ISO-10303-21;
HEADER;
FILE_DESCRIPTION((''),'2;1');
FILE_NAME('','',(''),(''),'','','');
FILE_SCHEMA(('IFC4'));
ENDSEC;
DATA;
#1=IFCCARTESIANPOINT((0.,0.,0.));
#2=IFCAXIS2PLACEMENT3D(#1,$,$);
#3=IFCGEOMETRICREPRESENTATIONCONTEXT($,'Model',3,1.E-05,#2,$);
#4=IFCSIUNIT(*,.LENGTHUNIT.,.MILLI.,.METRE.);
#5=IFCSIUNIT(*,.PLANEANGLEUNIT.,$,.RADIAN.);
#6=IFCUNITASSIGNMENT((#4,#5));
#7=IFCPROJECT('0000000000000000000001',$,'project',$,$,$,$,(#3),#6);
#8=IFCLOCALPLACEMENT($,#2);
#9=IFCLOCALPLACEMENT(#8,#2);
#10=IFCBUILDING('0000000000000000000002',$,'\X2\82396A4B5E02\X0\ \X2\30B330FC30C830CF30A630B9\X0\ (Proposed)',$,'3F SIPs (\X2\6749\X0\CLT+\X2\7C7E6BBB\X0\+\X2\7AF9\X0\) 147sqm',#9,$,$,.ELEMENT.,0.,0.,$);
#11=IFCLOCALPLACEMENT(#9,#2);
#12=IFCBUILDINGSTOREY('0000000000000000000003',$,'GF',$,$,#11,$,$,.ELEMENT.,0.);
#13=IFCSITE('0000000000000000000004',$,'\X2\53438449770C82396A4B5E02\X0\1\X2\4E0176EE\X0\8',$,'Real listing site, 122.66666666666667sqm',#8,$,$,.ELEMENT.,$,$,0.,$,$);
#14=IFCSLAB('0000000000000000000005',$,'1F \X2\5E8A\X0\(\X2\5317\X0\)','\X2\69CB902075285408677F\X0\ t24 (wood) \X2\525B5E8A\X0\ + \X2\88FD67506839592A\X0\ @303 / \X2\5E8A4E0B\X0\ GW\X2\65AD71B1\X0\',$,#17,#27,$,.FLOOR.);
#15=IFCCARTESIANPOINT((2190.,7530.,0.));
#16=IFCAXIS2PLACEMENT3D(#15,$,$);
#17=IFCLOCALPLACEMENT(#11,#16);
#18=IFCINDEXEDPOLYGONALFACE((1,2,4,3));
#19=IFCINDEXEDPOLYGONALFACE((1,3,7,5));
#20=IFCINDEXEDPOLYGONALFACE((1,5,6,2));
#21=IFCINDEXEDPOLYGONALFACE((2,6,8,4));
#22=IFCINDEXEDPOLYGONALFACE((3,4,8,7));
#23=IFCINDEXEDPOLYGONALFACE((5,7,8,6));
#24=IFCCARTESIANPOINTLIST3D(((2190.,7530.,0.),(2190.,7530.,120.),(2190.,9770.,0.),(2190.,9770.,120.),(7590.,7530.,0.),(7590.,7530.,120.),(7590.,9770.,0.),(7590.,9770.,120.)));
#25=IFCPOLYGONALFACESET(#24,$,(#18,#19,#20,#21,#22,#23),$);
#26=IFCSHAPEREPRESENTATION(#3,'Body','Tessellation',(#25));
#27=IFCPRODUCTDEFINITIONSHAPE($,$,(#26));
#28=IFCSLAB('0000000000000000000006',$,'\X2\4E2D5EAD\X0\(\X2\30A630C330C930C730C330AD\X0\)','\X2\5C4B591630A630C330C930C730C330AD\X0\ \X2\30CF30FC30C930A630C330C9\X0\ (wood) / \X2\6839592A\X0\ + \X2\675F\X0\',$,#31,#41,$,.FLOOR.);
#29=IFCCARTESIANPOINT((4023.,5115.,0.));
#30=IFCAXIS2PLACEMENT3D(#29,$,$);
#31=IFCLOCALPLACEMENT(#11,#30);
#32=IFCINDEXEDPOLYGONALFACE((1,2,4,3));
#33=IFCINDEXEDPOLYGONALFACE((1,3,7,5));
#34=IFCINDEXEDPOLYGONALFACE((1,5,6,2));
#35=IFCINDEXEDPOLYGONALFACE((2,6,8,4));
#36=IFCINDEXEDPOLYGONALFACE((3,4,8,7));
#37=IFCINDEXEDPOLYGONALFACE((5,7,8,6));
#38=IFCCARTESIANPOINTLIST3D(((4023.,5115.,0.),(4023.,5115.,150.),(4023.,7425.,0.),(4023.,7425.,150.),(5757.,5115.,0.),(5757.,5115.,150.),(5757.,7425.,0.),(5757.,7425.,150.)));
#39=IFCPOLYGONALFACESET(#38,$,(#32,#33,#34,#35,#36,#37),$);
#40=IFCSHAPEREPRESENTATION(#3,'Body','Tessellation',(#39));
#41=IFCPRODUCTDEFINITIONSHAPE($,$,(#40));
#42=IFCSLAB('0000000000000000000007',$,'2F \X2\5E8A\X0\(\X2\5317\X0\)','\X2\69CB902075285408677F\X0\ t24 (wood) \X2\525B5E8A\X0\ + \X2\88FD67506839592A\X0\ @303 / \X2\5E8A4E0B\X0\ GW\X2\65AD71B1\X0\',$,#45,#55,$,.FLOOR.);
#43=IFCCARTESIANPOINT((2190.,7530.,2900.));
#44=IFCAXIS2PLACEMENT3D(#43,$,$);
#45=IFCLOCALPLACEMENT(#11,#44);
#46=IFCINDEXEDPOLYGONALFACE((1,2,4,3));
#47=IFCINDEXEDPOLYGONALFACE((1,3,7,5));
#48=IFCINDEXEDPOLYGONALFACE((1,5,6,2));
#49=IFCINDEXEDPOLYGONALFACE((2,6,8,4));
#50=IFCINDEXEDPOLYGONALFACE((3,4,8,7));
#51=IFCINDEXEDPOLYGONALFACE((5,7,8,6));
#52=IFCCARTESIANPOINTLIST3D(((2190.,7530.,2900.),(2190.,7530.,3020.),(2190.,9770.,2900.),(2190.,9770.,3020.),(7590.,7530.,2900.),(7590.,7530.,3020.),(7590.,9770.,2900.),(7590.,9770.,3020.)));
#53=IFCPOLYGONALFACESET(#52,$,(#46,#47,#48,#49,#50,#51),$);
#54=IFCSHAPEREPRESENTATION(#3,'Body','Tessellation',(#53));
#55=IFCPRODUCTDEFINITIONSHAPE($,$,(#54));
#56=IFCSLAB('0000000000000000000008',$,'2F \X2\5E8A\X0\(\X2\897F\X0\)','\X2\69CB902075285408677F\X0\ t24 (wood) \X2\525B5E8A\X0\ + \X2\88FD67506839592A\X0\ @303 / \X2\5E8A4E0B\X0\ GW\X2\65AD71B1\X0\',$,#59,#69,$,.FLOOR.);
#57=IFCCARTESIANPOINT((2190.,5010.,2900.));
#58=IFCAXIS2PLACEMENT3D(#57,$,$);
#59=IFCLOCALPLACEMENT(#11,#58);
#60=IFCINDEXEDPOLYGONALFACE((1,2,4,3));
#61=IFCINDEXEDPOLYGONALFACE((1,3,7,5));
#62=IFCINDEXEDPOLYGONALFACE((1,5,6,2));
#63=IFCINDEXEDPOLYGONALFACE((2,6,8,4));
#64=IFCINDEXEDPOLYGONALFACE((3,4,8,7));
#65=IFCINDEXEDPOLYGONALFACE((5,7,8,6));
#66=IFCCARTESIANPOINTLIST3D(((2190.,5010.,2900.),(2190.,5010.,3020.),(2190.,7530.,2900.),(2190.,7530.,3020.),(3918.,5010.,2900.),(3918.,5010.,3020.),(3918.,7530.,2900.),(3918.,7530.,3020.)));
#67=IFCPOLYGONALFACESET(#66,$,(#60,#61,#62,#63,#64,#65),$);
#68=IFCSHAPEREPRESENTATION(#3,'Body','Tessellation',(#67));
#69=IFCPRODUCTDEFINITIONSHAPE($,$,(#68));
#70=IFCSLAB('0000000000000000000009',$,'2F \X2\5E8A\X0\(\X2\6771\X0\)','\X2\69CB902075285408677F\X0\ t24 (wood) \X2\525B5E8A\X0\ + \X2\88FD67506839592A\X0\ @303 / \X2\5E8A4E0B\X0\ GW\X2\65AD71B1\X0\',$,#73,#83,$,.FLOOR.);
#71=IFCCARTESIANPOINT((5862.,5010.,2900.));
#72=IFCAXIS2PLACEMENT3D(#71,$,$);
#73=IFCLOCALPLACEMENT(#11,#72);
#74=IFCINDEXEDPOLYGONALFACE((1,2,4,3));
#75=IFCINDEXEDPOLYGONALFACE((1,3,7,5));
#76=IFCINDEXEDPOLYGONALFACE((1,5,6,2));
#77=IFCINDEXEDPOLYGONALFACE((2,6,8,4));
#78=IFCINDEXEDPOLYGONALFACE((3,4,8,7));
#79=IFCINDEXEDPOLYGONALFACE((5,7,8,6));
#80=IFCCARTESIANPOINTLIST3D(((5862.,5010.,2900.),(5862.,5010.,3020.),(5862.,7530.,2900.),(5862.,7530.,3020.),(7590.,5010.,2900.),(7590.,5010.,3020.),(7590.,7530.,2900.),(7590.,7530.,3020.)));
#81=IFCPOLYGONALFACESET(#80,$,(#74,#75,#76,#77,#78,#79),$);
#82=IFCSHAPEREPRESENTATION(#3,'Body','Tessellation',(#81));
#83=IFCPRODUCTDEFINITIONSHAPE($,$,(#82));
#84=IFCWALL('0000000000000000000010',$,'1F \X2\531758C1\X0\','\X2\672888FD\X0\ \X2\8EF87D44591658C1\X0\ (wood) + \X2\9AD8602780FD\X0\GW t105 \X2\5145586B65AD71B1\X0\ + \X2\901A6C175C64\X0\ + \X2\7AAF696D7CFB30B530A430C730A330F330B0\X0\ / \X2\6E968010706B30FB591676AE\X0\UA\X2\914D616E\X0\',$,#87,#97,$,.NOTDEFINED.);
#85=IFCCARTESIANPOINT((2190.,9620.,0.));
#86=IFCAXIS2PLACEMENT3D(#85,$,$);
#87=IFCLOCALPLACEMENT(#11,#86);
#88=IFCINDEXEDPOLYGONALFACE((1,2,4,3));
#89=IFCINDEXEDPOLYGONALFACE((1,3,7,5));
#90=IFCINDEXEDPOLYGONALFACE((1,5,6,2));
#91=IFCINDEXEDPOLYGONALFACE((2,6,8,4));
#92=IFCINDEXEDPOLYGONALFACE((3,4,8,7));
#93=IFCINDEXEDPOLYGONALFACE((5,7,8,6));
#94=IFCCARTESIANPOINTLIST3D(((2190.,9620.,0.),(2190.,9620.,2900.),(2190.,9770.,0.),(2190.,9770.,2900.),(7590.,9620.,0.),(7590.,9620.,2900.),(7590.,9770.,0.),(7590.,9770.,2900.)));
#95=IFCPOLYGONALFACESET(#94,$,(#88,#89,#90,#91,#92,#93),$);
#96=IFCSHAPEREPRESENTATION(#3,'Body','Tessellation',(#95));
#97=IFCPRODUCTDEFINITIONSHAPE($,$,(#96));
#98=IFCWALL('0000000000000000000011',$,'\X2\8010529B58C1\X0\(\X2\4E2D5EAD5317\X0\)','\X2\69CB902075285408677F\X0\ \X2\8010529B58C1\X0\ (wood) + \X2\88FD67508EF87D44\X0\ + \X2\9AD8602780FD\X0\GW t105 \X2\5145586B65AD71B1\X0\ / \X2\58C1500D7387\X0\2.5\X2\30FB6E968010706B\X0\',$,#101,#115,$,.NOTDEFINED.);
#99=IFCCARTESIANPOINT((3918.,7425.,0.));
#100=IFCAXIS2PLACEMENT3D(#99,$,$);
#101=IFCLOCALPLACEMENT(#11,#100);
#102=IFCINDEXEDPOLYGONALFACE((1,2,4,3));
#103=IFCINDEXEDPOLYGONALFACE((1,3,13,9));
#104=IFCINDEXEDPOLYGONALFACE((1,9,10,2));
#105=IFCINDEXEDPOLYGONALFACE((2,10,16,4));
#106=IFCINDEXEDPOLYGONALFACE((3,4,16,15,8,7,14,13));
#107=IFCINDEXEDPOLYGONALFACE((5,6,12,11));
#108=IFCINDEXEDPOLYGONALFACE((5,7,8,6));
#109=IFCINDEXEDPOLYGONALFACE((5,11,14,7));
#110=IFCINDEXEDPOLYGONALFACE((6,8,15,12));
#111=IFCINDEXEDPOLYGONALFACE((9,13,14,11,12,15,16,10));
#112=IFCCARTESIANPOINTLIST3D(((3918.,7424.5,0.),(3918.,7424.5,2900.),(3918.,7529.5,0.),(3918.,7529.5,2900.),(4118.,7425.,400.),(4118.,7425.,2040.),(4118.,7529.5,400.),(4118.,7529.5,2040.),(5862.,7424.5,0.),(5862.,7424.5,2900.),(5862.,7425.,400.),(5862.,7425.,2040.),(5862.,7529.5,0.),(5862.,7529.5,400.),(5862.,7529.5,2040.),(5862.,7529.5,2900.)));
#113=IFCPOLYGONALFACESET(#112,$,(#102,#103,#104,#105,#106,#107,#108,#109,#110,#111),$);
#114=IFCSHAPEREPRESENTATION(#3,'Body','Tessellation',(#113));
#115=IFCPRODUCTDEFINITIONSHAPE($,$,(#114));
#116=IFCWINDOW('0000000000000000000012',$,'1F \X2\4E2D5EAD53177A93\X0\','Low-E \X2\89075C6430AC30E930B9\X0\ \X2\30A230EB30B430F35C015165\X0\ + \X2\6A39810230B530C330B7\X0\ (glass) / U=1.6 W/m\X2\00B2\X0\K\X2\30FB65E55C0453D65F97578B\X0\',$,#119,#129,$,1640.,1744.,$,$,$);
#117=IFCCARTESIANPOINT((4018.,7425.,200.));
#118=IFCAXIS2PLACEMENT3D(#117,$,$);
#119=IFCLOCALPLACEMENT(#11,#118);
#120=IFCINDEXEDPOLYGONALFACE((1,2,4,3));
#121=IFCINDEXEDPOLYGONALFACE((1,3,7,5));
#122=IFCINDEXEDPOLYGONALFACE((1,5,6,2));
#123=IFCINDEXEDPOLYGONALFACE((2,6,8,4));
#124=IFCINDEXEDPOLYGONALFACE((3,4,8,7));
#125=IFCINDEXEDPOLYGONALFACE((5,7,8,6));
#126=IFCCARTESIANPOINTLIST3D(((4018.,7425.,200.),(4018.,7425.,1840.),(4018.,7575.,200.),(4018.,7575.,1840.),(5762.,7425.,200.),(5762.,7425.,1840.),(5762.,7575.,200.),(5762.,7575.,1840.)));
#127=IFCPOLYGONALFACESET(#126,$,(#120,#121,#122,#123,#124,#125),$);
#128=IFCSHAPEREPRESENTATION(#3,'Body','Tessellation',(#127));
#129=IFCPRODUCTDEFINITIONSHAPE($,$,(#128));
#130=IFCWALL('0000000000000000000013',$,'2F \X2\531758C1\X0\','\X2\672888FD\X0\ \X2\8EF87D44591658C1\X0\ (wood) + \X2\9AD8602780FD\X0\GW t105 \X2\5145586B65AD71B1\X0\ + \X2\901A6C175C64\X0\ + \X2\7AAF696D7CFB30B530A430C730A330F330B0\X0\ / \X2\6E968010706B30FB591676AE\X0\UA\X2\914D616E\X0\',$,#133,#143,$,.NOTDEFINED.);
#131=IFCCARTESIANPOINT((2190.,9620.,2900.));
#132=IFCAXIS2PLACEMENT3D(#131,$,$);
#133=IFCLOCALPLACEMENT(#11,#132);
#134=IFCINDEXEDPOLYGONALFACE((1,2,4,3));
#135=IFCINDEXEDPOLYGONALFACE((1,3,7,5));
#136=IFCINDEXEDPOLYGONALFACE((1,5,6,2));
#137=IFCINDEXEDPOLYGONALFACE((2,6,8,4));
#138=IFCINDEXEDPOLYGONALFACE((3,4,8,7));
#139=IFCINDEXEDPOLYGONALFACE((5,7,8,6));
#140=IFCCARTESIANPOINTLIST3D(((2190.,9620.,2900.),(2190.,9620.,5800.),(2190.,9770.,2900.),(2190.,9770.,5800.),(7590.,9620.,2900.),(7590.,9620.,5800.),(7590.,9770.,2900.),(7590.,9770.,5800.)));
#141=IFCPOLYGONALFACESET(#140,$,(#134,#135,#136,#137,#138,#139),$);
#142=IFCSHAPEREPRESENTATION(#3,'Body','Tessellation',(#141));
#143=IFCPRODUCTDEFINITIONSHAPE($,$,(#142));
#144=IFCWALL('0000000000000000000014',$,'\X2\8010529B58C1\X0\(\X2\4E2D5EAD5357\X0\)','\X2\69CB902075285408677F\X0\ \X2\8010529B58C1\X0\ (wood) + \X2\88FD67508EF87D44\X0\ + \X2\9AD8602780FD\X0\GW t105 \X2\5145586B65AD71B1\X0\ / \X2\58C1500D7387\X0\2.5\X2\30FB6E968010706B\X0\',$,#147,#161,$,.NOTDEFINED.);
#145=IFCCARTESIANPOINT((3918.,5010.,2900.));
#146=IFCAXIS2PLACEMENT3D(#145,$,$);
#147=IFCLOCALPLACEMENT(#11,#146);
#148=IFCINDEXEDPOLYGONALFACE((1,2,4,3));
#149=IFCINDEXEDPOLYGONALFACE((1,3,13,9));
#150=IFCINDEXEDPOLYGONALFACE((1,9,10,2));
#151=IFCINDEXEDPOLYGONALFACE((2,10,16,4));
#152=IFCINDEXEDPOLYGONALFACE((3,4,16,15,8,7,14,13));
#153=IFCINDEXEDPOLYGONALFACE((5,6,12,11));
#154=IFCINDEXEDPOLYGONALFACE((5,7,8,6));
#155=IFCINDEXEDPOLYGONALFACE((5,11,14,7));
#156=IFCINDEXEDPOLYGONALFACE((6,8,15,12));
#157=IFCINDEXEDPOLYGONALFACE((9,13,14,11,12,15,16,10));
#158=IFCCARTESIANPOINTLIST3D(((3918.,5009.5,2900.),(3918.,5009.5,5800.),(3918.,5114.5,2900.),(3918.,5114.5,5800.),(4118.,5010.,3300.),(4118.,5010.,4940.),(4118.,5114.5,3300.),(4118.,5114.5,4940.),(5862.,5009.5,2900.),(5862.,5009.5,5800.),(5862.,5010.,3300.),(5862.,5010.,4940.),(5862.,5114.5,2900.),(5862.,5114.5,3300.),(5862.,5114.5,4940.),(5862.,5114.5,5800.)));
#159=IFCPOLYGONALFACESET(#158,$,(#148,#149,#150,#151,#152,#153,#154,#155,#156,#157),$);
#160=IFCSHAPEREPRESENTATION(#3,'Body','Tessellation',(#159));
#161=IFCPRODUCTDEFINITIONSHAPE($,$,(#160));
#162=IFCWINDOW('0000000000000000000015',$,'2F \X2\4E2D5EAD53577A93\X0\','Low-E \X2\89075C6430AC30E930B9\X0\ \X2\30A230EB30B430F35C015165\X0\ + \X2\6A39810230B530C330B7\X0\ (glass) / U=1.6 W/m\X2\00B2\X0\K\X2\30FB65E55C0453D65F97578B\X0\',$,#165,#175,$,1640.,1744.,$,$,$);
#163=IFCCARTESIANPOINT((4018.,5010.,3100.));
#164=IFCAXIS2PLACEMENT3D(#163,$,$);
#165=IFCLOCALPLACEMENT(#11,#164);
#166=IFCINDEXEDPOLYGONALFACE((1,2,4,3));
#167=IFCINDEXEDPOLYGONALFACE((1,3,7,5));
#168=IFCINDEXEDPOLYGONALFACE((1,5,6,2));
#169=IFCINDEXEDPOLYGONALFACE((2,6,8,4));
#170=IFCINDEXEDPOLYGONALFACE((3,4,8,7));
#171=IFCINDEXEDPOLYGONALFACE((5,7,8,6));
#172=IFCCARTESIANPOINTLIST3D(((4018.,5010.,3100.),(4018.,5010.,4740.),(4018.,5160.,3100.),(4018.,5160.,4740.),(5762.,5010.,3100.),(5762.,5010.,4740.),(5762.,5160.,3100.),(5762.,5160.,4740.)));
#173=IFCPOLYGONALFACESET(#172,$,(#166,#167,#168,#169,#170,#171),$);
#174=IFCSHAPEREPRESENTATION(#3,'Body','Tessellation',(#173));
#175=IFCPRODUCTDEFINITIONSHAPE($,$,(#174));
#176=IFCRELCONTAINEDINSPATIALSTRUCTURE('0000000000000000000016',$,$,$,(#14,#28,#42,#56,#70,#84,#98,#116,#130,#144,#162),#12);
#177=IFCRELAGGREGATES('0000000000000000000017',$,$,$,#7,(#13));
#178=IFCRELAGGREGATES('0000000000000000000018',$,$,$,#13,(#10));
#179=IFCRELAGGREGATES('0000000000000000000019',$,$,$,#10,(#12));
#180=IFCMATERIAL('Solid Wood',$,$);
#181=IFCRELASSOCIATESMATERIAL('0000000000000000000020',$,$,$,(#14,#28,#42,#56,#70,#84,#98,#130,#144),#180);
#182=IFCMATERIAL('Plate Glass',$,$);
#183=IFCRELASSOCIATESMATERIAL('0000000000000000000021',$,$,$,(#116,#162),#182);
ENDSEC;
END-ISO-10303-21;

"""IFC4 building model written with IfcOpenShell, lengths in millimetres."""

from ifc_helpers import new_model, si_unit, frame, frame_2d, origin, place, context, project, spatial, rectangle, extrude, material, element, fill, save


model = new_model("IFC4")

# Units and contexts
model_context = context("Model", 3, precision=1e-05, world=origin())
ifc_project = project(units=[si_unit("LENGTHUNIT", "METRE", prefix="MILLI"), si_unit("PLANEANGLEUNIT", "RADIAN")], contexts=[model_context])

# Site, building, storey
site_placement = place(None, origin())
site = spatial("IfcSite", under=ifc_project, at=site_placement, Name="千葉県船橋市1丁目8", ObjectType="Real listing site, 122.66666666666667sqm", CompositionType="ELEMENT", RefElevation=0.0)
building_placement = place(site_placement, origin())
building = spatial("IfcBuilding", under=site, at=building_placement, Name="船橋市 コートハウス (Proposed)", ObjectType="3F SIPs (杉CLT+籾殻+竹) 147sqm", CompositionType="ELEMENT", ElevationOfRefHeight=0.0, ElevationOfTerrain=0.0)
storey_placement = place(building_placement, origin())
storey = spatial("IfcBuildingStorey", under=building, at=storey_placement, Name="GF", CompositionType="ELEMENT", Elevation=0.0)

# Slabs
ifc_material_1 = material(Name="Solid Wood")
slab_1_placement = place(storey_placement, frame((2190.0, 7530.0, 0.0)))
element("IfcSlab", 1, at=slab_1_placement, inside=storey, material=ifc_material_1, Name="1F 床(北)", Description="構造用合板 t24 (wood) 剛床 + 製材根太 @303 / 床下 GW断熱", PredefinedType="FLOOR", context=model_context, shape_type="SweptSolid", body=[
    extrude(rectangle(XDim=5400.0, YDim=2240.0, at=frame_2d((2700.0, 1120.0))), frame((2190.0, 7530.0, 0.0)), (0.0, 0.0, 1.0), 120.0),
])
slab_2_placement = place(storey_placement, frame((4023.0, 5115.0, 0.0)))
element("IfcSlab", 2, at=slab_2_placement, inside=storey, material=ifc_material_1, Name="中庭(ウッドデッキ)", Description="屋外ウッドデッキ ハードウッド (wood) / 根太 + 束", PredefinedType="FLOOR", context=model_context, shape_type="SweptSolid", body=[
    extrude(rectangle(XDim=1734.0, YDim=2310.0, at=frame_2d((867.0, 1155.0))), frame((4023.0, 5115.0, 0.0)), (0.0, 0.0, 1.0), 150.0),
])
slab_3_placement = place(storey_placement, frame((2190.0, 7530.0, 2900.0)))
element("IfcSlab", 3, at=slab_3_placement, inside=storey, material=ifc_material_1, Name="2F 床(北)", Description="構造用合板 t24 (wood) 剛床 + 製材根太 @303 / 床下 GW断熱", PredefinedType="FLOOR", context=model_context, shape_type="SweptSolid", body=[
    extrude(rectangle(XDim=5400.0, YDim=2240.0, at=frame_2d((2700.0, 1120.0))), frame((2190.0, 7530.0, 2900.0)), (0.0, 0.0, 1.0), 120.0),
])
slab_4_placement = place(storey_placement, frame((2190.0, 5010.0, 2900.0)))
element("IfcSlab", 4, at=slab_4_placement, inside=storey, material=ifc_material_1, Name="2F 床(西)", Description="構造用合板 t24 (wood) 剛床 + 製材根太 @303 / 床下 GW断熱", PredefinedType="FLOOR", context=model_context, shape_type="SweptSolid", body=[
    extrude(rectangle(XDim=1728.0, YDim=2520.0, at=frame_2d((864.0, 1260.0))), frame((2190.0, 5010.0, 2900.0)), (0.0, 0.0, 1.0), 120.0),
])
slab_5_placement = place(storey_placement, frame((5862.0, 5010.0, 2900.0)))
element("IfcSlab", 5, at=slab_5_placement, inside=storey, material=ifc_material_1, Name="2F 床(東)", Description="構造用合板 t24 (wood) 剛床 + 製材根太 @303 / 床下 GW断熱", PredefinedType="FLOOR", context=model_context, shape_type="SweptSolid", body=[
    extrude(rectangle(XDim=1728.0, YDim=2520.0, at=frame_2d((864.0, 1260.0))), frame((5862.0, 5010.0, 2900.0)), (0.0, 0.0, 1.0), 120.0),
])

# Wall
wall_1_placement = place(storey_placement, frame((2190.0, 9620.0, 0.0)))
element("IfcWall", 6, at=wall_1_placement, inside=storey, material=ifc_material_1, Name="1F 北壁", Description="木製 軸組外壁 (wood) + 高性能GW t105 充填断熱 + 通気層 + 窯業系サイディング / 準耐火・外皮UA配慮", PredefinedType="NOTDEFINED", context=model_context, shape_type="SweptSolid", body=[
    extrude(rectangle(XDim=5400.0, YDim=150.0, at=frame_2d((2700.0, 75.0))), frame((2190.0, 9620.0, 0.0)), (0.0, 0.0, 1.0), 2900.0),
])

# Wall, opening, window
wall_2_placement = place(storey_placement, frame((3918.0, 7425.0, 0.0)))
wall_2 = element("IfcWall", 7, at=wall_2_placement, inside=storey, material=ifc_material_1, Name="耐力壁(中庭北)", Description="構造用合板 耐力壁 (wood) + 製材軸組 + 高性能GW t105 充填断熱 / 壁倍率2.5・準耐火", PredefinedType="NOTDEFINED", context=model_context, shape_type="SweptSolid", body=[
    extrude(rectangle(XDim=1944.0, YDim=105.0, at=frame_2d((972.0, 52.0))), frame((3918.0, 7425.0, 0.0)), (0.0, 0.0, 1.0), 2900.0),
])
opening_1_placement = place(storey_placement, frame((4018.0, 7425.0, 200.0)))
opening_1 = element("IfcOpeningElement", 8, at=opening_1_placement, cuts=wall_2, PredefinedType="NOTDEFINED", context=model_context, shape_type="SweptSolid", body=[
    extrude(rectangle(XDim=1744.0, YDim=150.0, at=frame_2d((872.0, 75.0))), frame((4018.0, 7425.0, 200.0)), (0.0, 0.0, 1.0), 1640.0),
])
ifc_material_2 = material(Name="Plate Glass")
window_1_placement = place(storey_placement, frame((4018.0, 7425.0, 200.0)))
window_1 = element("IfcWindow", 9, at=window_1_placement, inside=storey, material=ifc_material_2, Name="1F 中庭北窓", Description="Low-E 複層ガラス アルゴン封入 + 樹脂サッシ (glass) / U=1.6 W/m²K・日射取得型", OverallHeight=1640.0, OverallWidth=1744.0, context=model_context, shape_type="SweptSolid", body=[
    extrude(rectangle(XDim=1744.0, YDim=150.0, at=frame_2d((872.0, 75.0))), frame((4018.0, 7425.0, 200.0)), (0.0, 0.0, 1.0), 1640.0),
])
fill(opening_1, window_1)

# Wall
wall_3_placement = place(storey_placement, frame((2190.0, 9620.0, 2900.0)))
element("IfcWall", 10, at=wall_3_placement, inside=storey, material=ifc_material_1, Name="2F 北壁", Description="木製 軸組外壁 (wood) + 高性能GW t105 充填断熱 + 通気層 + 窯業系サイディング / 準耐火・外皮UA配慮", PredefinedType="NOTDEFINED", context=model_context, shape_type="SweptSolid", body=[
    extrude(rectangle(XDim=5400.0, YDim=150.0, at=frame_2d((2700.0, 75.0))), frame((2190.0, 9620.0, 2900.0)), (0.0, 0.0, 1.0), 2900.0),
])

# Wall, opening, window
wall_4_placement = place(storey_placement, frame((3918.0, 5010.0, 2900.0)))
wall_4 = element("IfcWall", 11, at=wall_4_placement, inside=storey, material=ifc_material_1, Name="耐力壁(中庭南)", Description="構造用合板 耐力壁 (wood) + 製材軸組 + 高性能GW t105 充填断熱 / 壁倍率2.5・準耐火", PredefinedType="NOTDEFINED", context=model_context, shape_type="SweptSolid", body=[
    extrude(rectangle(XDim=1944.0, YDim=105.0, at=frame_2d((972.0, 52.0))), frame((3918.0, 5010.0, 2900.0)), (0.0, 0.0, 1.0), 2900.0),
])
opening_2_placement = place(storey_placement, frame((4018.0, 5010.0, 3100.0)))
opening_2 = element("IfcOpeningElement", 12, at=opening_2_placement, cuts=wall_4, PredefinedType="NOTDEFINED", context=model_context, shape_type="SweptSolid", body=[
    extrude(rectangle(XDim=1744.0, YDim=150.0, at=frame_2d((872.0, 75.0))), frame((4018.0, 5010.0, 3100.0)), (0.0, 0.0, 1.0), 1640.0),
])
window_2_placement = place(storey_placement, frame((4018.0, 5010.0, 3100.0)))
window_2 = element("IfcWindow", 13, at=window_2_placement, inside=storey, material=ifc_material_2, Name="2F 中庭南窓", Description="Low-E 複層ガラス アルゴン封入 + 樹脂サッシ (glass) / U=1.6 W/m²K・日射取得型", OverallHeight=1640.0, OverallWidth=1744.0, context=model_context, shape_type="SweptSolid", body=[
    extrude(rectangle(XDim=1744.0, YDim=150.0, at=frame_2d((872.0, 75.0))), frame((4018.0, 5010.0, 3100.0)), (0.0, 0.0, 1.0), 1640.0),
])
fill(opening_2, window_2)

save(model, "model.ifc")
